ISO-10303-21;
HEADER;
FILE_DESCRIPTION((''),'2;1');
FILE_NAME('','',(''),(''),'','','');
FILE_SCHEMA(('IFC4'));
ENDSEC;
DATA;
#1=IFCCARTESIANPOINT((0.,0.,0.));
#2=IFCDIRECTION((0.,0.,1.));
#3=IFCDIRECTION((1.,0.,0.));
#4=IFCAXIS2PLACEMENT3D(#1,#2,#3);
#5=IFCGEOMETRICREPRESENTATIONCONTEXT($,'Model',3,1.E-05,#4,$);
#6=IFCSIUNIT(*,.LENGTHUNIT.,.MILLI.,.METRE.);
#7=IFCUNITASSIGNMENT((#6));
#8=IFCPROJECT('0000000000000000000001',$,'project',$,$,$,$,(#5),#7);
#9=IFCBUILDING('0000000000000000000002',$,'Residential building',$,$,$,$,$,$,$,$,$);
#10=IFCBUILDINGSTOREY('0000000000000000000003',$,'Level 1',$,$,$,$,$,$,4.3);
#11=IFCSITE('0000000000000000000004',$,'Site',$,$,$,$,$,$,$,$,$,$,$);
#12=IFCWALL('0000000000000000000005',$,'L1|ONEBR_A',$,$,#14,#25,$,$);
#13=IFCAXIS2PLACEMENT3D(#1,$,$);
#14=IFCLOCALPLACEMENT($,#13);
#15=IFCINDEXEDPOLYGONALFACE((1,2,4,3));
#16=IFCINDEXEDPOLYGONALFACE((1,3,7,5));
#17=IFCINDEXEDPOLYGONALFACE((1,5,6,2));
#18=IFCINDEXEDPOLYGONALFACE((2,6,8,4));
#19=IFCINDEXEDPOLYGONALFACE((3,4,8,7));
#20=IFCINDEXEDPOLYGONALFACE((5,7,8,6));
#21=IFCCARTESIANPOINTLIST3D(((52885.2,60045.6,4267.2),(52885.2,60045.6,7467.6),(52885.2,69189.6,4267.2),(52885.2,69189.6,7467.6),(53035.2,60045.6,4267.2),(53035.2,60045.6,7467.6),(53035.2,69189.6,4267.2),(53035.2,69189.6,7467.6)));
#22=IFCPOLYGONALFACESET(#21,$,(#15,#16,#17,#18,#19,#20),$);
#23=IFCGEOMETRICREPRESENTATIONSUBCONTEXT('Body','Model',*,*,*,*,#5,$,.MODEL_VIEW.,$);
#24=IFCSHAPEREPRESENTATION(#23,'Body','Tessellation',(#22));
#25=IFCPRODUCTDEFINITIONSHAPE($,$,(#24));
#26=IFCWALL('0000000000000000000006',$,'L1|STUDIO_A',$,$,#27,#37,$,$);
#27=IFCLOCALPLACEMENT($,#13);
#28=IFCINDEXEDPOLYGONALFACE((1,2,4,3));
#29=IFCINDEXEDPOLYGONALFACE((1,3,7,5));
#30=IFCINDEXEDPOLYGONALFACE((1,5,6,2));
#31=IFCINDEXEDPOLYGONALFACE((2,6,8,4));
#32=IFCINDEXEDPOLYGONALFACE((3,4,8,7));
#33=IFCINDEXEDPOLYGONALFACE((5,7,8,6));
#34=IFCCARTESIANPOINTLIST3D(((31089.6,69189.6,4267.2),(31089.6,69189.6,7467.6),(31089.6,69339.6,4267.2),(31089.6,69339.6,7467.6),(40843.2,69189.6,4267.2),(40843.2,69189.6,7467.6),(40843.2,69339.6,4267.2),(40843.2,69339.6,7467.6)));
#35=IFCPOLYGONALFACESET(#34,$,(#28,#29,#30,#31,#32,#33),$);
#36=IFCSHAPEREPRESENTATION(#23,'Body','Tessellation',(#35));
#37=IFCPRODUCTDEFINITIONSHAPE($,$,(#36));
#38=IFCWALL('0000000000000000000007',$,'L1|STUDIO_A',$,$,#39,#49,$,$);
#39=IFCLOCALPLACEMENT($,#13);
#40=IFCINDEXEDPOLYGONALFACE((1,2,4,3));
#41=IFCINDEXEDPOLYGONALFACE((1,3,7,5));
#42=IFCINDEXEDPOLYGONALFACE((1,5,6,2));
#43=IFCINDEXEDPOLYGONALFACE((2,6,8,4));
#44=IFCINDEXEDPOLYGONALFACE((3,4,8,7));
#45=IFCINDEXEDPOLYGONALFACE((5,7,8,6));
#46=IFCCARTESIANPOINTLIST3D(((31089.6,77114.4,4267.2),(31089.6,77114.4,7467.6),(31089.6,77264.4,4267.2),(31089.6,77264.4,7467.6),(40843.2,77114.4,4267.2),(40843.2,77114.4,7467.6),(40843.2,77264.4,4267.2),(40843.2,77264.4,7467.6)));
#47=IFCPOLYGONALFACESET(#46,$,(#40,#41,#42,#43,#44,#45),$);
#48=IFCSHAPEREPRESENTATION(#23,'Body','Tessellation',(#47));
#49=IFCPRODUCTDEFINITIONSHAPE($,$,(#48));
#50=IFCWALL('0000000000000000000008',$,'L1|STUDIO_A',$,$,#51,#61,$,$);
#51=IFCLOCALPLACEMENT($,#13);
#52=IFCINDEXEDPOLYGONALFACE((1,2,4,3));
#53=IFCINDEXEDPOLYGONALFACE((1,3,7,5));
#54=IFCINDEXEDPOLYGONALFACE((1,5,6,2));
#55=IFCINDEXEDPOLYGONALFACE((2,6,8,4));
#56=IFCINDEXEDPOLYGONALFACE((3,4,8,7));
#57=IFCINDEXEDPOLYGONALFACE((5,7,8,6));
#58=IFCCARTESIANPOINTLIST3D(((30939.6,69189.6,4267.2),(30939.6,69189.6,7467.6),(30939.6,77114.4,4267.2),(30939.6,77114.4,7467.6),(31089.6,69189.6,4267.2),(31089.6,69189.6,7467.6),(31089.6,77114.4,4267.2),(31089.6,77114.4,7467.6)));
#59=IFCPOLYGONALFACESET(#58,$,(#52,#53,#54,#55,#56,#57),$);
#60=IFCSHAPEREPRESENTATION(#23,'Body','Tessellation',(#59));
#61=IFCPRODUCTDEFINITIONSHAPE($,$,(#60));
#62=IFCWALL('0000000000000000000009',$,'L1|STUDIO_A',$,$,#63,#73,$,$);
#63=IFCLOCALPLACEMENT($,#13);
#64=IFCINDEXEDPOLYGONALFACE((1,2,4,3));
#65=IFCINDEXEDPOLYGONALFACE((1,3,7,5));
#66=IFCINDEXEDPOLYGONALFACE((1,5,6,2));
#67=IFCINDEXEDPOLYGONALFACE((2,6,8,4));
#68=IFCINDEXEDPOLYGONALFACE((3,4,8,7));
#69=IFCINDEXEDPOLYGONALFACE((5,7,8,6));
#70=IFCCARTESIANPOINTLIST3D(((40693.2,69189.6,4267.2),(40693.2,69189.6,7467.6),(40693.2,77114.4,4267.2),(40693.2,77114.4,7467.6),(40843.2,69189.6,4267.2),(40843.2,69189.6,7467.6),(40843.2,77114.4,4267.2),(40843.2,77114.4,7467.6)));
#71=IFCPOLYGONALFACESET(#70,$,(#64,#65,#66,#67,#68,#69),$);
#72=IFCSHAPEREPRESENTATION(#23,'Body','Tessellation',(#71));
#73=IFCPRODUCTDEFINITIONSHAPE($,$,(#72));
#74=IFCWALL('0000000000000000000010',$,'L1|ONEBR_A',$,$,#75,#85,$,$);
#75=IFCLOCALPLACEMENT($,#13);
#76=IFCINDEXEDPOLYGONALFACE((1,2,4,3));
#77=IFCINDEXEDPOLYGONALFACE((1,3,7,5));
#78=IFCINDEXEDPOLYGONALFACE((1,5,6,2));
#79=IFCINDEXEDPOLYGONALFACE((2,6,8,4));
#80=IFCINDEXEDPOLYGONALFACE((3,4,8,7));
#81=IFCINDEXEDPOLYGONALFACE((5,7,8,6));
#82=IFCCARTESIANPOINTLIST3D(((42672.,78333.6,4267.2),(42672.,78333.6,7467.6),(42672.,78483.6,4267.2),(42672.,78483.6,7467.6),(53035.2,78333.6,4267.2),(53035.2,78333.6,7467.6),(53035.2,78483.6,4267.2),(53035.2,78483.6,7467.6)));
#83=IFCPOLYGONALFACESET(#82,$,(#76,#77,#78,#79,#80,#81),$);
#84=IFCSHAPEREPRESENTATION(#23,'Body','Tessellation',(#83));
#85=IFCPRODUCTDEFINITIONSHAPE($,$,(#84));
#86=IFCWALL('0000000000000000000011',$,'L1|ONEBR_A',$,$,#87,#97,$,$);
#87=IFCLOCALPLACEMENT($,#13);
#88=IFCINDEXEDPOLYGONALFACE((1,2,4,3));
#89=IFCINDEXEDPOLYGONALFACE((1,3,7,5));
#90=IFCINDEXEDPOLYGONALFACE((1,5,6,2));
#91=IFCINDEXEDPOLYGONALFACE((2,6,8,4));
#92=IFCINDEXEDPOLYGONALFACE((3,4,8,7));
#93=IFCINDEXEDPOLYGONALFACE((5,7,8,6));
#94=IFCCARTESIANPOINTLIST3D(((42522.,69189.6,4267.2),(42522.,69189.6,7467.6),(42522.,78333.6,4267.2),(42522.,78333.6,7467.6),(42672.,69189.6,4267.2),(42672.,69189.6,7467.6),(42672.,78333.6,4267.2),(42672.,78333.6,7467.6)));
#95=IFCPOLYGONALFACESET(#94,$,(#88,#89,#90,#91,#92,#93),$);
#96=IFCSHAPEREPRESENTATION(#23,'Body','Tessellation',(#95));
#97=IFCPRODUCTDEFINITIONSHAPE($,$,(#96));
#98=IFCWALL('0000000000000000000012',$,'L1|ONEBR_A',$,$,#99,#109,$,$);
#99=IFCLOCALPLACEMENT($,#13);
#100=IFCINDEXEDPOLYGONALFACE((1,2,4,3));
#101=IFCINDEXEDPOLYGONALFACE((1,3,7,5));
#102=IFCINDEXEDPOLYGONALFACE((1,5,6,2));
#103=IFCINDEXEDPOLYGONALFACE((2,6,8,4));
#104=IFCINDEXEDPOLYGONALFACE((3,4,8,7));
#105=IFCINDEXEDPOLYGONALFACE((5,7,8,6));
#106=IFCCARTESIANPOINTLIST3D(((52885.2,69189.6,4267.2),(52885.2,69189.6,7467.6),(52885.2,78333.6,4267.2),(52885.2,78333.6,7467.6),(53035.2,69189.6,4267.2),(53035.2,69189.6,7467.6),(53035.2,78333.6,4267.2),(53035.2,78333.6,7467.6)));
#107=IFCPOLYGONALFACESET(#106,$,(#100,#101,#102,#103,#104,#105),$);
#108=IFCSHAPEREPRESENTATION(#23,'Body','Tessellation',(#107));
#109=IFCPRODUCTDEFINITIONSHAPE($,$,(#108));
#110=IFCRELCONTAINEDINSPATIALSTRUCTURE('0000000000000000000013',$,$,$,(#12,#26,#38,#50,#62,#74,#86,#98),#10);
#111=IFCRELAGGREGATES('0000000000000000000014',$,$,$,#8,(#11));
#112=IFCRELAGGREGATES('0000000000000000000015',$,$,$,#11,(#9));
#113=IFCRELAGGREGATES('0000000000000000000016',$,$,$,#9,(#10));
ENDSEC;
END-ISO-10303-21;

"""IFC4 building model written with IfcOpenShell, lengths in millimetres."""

from ifc_helpers import new_model, si_unit, frame, origin_with_axes, place, context, subcontext, project, spatial, indexed_curve, outline, extrude, element, save


model = new_model("IFC4")

# Units and contexts
model_context = context("Model", 3, precision=1e-05, world=origin_with_axes())
body_context = subcontext(model_context, "Body", "Model", "MODEL_VIEW")
ifc_project = project(units=[si_unit("LENGTHUNIT", "METRE", prefix="MILLI")], contexts=[model_context])

# Site, building, storey
site = spatial("IfcSite", under=ifc_project, Name="Site")
building = spatial("IfcBuilding", under=site, Name="Residential building")
storey = spatial("IfcBuildingStorey", under=building, Name="Level 1", Elevation=4.3)

# Walls
for number, where, z_axis, x_axis, name in (
    (1, (53035.2, 60045.6, 4267.2), (0.0, 0.0, 1.0), (0.0, 1.0, 0.0), "L1|ONEBR_A"),
):
    element("IfcWall", number, at=place(None, frame(where, z_axis=z_axis, x_axis=x_axis)), inside=storey, Name=name, context=body_context, shape_type="SweptSolid", body=[
        extrude(outline(indexed_curve([(0.0, 0.0), (0.0, 150.0), (9144.0, 150.0), (9144.0, 0.0), (0.0, 0.0)], self_intersect=False)), origin_with_axes(), (0.0, 0.0, 1.0), 3200.4),
    ])
for number, where, z_axis, x_axis, name in (
    (2, (31089.6, 69189.6, 4267.2), (0.0, 0.0, 1.0), (1.0, 0.0, 0.0), "L1|STUDIO_A"),
    (3, (31089.6, 77114.4, 4267.2), (0.0, 0.0, 1.0), (1.0, 0.0, 0.0), "L1|STUDIO_A"),
):
    element("IfcWall", number, at=place(None, frame(where, z_axis=z_axis, x_axis=x_axis)), inside=storey, Name=name, context=body_context, shape_type="SweptSolid", body=[
        extrude(outline(indexed_curve([(0.0, 0.0), (0.0, 150.0), (9753.6, 150.0), (9753.6, 0.0), (0.0, 0.0)], self_intersect=False)), origin_with_axes(), (0.0, 0.0, 1.0), 3200.4),
    ])
for number, where, z_axis, x_axis, name in (
    (4, (31089.6, 69189.6, 4267.2), (0.0, 0.0, 1.0), (0.0, 1.0, 0.0), "L1|STUDIO_A"),
    (5, (40843.2, 69189.6, 4267.2), (0.0, 0.0, 1.0), (0.0, 1.0, 0.0), "L1|STUDIO_A"),
):
    element("IfcWall", number, at=place(None, frame(where, z_axis=z_axis, x_axis=x_axis)), inside=storey, Name=name, context=body_context, shape_type="SweptSolid", body=[
        extrude(outline(indexed_curve([(0.0, 0.0), (0.0, 150.0), (7924.8, 150.0), (7924.8, 0.0), (0.0, 0.0)], self_intersect=False)), origin_with_axes(), (0.0, 0.0, 1.0), 3200.4),
    ])
for number, where, z_axis, x_axis, name in (
    (6, (42672.0, 78333.6, 4267.2), (0.0, 0.0, 1.0), (1.0, 0.0, 0.0), "L1|ONEBR_A"),
):
    element("IfcWall", number, at=place(None, frame(where, z_axis=z_axis, x_axis=x_axis)), inside=storey, Name=name, context=body_context, shape_type="SweptSolid", body=[
        extrude(outline(indexed_curve([(0.0, 0.0), (0.0, 150.0), (10363.2, 150.0), (10363.2, 0.0), (0.0, 0.0)], self_intersect=False)), origin_with_axes(), (0.0, 0.0, 1.0), 3200.4),
    ])
for number, where, z_axis, x_axis, name in (
    (7, (42672.0, 69189.6, 4267.2), (0.0, 0.0, 1.0), (0.0, 1.0, 0.0), "L1|ONEBR_A"),
    (8, (53035.2, 69189.6, 4267.2), (0.0, 0.0, 1.0), (0.0, 1.0, 0.0), "L1|ONEBR_A"),
):
    element("IfcWall", number, at=place(None, frame(where, z_axis=z_axis, x_axis=x_axis)), inside=storey, Name=name, context=body_context, shape_type="SweptSolid", body=[
        extrude(outline(indexed_curve([(0.0, 0.0), (0.0, 150.0), (9144.0, 150.0), (9144.0, 0.0), (0.0, 0.0)], self_intersect=False)), origin_with_axes(), (0.0, 0.0, 1.0), 3200.4),
    ])

save(model, "model.ifc")
